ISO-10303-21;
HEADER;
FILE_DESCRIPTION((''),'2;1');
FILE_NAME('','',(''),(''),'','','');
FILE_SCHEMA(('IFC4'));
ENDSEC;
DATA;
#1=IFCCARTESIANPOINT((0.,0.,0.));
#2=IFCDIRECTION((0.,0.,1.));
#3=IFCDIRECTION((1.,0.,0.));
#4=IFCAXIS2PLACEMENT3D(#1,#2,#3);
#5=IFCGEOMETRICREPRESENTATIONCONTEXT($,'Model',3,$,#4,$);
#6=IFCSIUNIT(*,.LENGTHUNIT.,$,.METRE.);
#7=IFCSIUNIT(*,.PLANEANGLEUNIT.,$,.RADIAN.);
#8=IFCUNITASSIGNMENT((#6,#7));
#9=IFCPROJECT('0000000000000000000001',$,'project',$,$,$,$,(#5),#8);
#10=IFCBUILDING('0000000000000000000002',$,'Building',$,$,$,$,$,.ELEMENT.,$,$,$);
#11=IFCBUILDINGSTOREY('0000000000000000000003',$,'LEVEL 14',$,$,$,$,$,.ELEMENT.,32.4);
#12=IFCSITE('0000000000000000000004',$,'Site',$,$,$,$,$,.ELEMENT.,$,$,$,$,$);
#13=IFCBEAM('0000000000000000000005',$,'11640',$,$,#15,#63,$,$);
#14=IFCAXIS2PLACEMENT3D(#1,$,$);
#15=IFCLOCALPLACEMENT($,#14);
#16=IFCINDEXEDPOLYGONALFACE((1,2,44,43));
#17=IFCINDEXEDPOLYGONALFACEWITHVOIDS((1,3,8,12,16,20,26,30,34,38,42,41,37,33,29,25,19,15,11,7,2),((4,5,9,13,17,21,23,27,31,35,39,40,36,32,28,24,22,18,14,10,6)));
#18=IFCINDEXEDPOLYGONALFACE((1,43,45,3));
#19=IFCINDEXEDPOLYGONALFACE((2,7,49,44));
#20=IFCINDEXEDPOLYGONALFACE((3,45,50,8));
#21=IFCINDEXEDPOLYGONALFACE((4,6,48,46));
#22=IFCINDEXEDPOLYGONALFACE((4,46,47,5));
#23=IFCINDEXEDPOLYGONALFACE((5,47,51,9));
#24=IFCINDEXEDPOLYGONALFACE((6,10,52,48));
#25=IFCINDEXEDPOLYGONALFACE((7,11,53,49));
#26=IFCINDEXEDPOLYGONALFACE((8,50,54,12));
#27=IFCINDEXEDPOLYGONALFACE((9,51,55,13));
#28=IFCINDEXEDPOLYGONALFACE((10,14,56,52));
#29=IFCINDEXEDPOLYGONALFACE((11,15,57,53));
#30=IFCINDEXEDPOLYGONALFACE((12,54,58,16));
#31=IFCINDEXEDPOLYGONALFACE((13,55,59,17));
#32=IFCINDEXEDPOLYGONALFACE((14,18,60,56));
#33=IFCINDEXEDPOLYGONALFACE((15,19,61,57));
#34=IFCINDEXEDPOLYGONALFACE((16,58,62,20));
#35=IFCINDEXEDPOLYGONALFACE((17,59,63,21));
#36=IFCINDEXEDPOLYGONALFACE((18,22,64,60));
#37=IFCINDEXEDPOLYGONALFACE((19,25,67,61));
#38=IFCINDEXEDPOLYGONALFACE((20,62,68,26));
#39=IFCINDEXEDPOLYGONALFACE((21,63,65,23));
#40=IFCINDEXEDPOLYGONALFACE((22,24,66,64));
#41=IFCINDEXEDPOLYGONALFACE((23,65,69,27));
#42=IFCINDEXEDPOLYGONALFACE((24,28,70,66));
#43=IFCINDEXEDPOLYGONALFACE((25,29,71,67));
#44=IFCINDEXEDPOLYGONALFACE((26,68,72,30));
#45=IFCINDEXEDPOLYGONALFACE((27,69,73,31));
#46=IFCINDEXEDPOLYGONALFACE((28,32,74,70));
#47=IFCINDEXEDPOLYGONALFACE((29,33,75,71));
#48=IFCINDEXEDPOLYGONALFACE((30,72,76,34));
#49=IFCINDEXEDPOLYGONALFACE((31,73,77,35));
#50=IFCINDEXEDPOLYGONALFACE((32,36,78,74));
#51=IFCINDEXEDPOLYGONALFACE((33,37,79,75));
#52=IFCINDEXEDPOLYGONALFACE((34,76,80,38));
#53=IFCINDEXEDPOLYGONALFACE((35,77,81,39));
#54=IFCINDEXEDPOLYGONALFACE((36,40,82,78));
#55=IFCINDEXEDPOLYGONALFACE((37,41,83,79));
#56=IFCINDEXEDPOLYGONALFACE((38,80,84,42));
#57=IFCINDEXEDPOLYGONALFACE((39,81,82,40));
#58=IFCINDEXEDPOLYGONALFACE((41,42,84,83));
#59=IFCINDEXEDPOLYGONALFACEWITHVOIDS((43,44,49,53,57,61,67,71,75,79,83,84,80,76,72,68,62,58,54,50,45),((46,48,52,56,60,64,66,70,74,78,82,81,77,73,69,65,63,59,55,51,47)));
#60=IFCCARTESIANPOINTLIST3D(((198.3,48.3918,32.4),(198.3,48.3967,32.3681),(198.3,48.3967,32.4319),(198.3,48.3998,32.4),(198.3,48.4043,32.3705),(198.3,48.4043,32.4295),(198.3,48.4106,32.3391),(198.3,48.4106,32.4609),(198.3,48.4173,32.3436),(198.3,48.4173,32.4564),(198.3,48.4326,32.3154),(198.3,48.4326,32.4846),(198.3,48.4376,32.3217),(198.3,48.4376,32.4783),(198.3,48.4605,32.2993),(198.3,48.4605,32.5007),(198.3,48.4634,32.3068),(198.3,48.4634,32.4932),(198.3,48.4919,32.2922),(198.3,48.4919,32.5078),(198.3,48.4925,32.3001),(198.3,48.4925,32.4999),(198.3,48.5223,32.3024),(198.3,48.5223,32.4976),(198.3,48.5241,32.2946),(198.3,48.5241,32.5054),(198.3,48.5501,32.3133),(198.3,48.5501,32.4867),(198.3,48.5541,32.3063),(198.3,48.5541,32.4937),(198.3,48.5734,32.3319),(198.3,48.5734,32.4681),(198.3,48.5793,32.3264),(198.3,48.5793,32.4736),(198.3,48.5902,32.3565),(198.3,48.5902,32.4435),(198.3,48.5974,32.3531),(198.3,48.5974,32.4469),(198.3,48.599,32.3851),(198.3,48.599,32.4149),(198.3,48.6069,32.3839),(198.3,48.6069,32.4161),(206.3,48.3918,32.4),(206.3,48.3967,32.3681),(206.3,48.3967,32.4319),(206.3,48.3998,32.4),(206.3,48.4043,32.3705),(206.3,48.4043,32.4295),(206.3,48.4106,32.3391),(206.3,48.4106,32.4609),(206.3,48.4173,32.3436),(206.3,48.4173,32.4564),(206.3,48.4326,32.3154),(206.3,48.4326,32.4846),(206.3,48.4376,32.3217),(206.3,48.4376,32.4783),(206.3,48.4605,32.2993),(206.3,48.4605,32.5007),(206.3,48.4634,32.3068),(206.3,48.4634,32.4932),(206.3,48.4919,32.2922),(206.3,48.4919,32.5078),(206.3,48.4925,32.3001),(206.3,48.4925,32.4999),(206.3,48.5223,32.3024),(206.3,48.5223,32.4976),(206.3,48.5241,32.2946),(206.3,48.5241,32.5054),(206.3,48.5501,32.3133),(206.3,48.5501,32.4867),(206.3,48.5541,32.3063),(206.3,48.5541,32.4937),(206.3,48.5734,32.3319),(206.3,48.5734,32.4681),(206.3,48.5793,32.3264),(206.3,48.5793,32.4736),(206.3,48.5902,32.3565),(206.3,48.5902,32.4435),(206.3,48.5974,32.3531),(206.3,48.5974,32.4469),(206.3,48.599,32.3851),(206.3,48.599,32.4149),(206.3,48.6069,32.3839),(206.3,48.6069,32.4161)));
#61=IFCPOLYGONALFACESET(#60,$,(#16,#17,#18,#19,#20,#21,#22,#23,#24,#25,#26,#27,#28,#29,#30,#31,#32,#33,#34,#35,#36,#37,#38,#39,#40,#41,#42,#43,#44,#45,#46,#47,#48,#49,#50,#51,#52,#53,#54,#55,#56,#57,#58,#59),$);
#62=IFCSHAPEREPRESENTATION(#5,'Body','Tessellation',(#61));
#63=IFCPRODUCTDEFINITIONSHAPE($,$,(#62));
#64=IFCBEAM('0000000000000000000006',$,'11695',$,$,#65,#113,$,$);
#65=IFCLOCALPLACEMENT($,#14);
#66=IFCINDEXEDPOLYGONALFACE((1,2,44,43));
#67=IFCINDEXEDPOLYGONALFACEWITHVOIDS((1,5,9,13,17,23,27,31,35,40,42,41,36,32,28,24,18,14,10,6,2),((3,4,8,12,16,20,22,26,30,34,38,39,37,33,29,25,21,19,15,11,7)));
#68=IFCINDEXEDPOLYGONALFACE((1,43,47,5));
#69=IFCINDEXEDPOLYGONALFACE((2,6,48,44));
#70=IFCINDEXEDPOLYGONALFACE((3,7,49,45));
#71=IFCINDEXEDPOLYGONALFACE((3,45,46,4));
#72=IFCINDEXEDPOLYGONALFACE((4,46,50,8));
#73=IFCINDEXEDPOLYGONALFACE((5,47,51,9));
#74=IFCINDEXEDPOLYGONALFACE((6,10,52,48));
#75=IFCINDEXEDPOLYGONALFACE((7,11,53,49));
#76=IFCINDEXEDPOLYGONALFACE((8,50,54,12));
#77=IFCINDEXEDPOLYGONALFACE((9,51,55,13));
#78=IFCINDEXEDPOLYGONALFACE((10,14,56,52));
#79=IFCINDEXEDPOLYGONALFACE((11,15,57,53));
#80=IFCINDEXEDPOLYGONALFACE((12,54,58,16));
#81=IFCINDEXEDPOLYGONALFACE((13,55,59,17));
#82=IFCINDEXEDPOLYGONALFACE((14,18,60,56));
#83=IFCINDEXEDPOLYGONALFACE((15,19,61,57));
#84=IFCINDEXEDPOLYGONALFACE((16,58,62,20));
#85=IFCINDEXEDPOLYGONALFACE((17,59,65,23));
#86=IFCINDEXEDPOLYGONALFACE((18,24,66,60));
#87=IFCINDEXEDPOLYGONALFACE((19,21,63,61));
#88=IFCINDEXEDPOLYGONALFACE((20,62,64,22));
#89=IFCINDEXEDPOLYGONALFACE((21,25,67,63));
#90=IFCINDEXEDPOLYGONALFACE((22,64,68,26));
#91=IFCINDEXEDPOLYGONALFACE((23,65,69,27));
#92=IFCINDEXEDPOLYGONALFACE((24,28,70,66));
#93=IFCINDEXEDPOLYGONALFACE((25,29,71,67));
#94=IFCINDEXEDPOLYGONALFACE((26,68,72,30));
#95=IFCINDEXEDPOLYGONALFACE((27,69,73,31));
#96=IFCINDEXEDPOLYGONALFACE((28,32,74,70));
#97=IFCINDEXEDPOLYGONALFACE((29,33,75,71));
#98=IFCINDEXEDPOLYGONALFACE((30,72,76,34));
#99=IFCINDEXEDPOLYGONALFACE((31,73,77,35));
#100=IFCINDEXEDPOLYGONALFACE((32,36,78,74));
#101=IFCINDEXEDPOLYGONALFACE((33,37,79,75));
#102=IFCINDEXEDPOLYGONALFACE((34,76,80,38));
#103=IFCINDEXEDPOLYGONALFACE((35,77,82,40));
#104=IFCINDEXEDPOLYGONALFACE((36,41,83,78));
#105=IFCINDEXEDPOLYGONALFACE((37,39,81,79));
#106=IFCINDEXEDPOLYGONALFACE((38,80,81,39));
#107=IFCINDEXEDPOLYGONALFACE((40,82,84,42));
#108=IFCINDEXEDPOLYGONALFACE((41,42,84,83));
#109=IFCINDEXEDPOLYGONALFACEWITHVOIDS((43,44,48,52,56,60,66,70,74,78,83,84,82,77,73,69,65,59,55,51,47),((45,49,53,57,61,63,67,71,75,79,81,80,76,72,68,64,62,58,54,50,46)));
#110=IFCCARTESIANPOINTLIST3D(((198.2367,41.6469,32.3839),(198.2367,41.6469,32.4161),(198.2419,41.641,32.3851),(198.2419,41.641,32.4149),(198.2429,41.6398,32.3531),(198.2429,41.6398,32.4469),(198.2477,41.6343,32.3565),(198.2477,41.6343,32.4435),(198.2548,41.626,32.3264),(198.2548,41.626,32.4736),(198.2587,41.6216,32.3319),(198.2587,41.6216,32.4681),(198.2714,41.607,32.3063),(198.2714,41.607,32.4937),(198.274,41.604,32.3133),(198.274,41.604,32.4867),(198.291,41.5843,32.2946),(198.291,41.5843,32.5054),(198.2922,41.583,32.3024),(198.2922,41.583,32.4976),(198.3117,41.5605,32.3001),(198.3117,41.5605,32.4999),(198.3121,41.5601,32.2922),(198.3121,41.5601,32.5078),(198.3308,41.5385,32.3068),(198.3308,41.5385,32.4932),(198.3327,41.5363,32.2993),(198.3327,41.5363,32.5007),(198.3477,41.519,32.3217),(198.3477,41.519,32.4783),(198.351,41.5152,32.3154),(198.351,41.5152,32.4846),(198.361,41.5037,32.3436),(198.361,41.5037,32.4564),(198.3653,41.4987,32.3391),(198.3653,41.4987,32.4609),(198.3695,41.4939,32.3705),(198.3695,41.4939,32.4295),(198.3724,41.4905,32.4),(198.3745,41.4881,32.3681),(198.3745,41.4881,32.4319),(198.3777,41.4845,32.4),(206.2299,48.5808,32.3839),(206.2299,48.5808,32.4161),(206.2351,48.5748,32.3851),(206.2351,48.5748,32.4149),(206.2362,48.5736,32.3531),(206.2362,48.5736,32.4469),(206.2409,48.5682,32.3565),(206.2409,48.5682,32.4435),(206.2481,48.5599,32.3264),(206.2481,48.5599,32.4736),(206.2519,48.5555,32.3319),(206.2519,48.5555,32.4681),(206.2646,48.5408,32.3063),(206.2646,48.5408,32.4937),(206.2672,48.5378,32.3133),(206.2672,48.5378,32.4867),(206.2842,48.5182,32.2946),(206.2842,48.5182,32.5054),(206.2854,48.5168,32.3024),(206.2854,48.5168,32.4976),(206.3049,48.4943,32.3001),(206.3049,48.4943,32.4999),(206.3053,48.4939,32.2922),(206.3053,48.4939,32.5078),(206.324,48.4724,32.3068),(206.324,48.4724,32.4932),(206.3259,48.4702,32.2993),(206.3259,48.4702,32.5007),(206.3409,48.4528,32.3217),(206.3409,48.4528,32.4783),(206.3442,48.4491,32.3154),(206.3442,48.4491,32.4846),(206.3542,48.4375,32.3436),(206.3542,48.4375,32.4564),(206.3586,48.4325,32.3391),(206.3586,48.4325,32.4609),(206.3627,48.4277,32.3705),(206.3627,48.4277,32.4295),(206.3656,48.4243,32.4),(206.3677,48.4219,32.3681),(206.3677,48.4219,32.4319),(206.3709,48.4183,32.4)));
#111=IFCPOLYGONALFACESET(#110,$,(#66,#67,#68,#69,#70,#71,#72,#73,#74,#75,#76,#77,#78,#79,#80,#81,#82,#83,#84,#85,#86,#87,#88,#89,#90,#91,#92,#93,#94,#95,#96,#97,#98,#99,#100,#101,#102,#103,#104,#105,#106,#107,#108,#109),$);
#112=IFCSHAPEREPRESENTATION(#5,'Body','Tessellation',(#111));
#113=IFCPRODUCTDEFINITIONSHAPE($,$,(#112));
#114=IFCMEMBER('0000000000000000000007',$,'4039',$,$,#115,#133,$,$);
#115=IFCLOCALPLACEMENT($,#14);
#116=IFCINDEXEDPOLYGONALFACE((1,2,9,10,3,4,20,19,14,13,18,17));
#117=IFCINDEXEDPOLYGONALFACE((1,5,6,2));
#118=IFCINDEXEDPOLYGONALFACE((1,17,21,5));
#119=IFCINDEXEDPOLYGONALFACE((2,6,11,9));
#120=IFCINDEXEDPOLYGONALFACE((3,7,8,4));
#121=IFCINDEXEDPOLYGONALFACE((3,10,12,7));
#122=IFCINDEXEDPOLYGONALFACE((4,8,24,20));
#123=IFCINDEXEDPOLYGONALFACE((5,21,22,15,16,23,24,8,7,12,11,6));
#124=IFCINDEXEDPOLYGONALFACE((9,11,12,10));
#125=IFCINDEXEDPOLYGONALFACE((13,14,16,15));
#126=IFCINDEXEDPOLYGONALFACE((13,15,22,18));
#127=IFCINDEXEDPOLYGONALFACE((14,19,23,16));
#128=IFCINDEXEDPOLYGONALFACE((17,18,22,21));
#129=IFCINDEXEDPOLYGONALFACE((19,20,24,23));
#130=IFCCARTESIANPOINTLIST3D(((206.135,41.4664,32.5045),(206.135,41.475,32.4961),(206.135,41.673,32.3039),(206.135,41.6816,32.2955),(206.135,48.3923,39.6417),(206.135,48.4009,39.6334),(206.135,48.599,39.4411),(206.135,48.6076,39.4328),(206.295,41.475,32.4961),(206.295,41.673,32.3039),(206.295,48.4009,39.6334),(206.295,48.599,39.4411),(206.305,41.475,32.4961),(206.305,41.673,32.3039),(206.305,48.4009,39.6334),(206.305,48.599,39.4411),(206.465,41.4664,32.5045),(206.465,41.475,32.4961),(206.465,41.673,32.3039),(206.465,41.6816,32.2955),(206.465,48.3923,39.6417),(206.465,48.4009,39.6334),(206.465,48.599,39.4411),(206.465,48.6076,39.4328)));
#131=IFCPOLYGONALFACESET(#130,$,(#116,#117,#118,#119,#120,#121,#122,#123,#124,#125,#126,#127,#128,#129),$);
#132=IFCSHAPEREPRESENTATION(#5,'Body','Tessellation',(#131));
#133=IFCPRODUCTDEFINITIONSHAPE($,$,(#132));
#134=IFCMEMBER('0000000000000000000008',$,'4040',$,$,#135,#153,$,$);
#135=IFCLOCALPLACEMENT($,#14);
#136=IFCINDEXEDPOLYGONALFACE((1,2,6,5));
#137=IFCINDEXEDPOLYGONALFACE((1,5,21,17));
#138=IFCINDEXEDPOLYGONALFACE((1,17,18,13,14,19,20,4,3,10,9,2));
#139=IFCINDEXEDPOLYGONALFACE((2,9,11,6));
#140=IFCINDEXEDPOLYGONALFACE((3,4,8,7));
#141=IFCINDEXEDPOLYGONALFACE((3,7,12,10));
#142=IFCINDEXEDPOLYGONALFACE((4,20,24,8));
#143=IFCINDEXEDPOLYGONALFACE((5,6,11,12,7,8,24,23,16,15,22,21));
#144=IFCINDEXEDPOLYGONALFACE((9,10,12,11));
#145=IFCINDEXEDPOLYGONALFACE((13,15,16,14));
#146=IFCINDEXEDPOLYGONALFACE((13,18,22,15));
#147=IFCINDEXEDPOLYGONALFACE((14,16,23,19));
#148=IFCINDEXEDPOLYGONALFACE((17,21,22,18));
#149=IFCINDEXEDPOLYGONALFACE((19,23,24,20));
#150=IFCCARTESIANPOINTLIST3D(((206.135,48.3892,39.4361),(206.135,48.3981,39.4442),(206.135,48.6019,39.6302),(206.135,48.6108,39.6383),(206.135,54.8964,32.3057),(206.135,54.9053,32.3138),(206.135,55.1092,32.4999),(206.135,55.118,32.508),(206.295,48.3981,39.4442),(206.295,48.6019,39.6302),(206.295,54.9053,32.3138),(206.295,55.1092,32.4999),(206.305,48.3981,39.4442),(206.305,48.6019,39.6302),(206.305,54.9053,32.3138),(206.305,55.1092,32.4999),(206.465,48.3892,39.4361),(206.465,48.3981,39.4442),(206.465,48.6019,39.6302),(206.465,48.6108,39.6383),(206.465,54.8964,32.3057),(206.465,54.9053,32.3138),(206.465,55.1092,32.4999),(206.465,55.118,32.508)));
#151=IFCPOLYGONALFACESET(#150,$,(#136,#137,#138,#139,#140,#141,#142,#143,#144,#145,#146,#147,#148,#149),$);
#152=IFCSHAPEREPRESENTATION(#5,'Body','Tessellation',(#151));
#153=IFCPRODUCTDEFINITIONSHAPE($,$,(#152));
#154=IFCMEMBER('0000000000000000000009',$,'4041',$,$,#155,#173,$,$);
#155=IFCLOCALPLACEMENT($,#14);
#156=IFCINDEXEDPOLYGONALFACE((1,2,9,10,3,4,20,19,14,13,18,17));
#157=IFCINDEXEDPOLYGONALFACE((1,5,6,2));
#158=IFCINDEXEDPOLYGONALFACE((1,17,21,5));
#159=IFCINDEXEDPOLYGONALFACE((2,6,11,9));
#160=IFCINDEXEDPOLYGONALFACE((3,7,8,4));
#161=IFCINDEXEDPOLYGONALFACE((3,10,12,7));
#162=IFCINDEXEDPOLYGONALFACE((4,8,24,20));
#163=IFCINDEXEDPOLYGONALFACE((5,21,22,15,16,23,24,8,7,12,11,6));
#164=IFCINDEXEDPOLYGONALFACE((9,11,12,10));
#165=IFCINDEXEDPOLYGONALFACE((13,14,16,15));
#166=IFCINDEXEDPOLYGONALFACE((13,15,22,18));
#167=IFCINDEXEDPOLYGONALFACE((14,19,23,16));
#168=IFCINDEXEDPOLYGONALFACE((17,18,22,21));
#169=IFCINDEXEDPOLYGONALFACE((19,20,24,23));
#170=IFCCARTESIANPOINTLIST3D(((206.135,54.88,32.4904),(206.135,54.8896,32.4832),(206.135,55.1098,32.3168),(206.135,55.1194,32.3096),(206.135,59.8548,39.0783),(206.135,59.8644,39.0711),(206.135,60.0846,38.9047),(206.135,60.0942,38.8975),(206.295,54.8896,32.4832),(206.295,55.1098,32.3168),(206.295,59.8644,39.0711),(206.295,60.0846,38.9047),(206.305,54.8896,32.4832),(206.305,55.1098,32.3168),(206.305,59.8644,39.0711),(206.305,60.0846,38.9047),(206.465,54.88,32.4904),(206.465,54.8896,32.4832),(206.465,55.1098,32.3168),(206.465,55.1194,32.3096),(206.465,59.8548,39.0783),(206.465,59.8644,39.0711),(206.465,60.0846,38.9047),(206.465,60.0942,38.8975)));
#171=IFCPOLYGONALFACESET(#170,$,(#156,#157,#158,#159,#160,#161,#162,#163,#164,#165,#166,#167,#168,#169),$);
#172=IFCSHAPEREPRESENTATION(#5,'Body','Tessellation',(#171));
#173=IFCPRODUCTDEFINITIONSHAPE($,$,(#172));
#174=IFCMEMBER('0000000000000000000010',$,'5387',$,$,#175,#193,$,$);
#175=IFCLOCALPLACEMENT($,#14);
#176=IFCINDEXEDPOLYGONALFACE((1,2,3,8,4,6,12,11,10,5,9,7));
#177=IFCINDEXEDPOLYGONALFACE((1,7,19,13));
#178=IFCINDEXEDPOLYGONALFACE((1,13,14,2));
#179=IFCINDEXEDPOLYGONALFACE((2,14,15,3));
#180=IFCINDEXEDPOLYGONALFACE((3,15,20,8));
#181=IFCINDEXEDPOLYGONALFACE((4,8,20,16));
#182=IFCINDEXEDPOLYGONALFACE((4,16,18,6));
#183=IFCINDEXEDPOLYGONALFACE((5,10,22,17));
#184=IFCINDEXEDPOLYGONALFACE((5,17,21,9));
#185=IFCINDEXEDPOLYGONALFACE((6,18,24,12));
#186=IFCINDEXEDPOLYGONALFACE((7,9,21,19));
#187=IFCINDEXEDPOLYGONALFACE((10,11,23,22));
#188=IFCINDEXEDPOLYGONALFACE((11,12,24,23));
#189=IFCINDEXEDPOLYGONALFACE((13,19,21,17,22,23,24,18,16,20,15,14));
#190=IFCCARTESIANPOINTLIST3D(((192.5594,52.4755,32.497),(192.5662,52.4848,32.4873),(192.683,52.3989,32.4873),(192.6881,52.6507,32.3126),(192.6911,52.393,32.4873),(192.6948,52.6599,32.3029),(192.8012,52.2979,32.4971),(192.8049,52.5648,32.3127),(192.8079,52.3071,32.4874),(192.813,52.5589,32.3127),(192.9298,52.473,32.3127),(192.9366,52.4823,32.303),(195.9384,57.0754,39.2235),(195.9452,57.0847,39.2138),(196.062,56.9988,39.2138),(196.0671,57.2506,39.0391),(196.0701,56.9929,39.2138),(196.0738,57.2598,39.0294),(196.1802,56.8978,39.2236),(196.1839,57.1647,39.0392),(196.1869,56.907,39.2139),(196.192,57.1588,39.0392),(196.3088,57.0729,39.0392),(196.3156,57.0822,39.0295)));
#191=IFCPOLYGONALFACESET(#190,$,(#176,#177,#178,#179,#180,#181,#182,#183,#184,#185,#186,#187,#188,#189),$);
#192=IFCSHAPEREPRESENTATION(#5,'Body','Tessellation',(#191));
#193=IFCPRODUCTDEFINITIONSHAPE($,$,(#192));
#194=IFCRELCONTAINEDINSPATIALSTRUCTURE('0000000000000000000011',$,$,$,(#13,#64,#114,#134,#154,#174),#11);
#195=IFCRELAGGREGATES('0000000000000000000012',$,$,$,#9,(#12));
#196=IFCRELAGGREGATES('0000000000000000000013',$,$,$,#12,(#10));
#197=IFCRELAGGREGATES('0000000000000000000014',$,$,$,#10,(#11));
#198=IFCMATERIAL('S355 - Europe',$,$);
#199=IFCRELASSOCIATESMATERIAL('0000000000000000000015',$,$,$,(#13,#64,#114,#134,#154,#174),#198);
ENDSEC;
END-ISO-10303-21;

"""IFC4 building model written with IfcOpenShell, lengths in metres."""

from ifc_helpers import new_model, si_unit, frame, origin_with_axes, origin_2d_with_axis, place, context, project, spatial, hollow_circle, i_section, extrude, material, material_profile, profile_set, profile_usage, element, save


model = new_model("IFC4")

# Units and contexts
model_context = context("Model", 3, world=origin_with_axes())
ifc_project = project(units=[si_unit("LENGTHUNIT", "METRE"), si_unit("PLANEANGLEUNIT", "RADIAN")], contexts=[model_context])

# Site, building, storey
site = spatial("IfcSite", under=ifc_project, Name="Site", CompositionType="ELEMENT")
building = spatial("IfcBuilding", under=site, Name="Building", CompositionType="ELEMENT")
storey = spatial("IfcBuildingStorey", under=building, Name="LEVEL 14", CompositionType="ELEMENT", Elevation=32.4)

# Shared definitions
ifc_material = material(Name="S355 - Europe")

# Beams
ifc_material_profile_1 = material_profile(ifc_material, hollow_circle(Radius=0.1081, WallThickness=0.008, at=origin_2d_with_axis()))
ifc_profile_set_1 = profile_set([ifc_material_profile_1])
ifc_profile_usage_1 = profile_usage(ifc_profile_set_1, cardinal=10)
beam_1_placement = place(None, frame((206.3, 48.5, 32.4), z_axis=(-1.0, 0.0, 0.0), x_axis=(0.0, -1.0, 0.0)))
element("IfcBeam", 1, at=beam_1_placement, inside=storey, material=ifc_profile_usage_1, Name="11640", context=model_context, shape_type="SweptSolid", body=[
    extrude(hollow_circle(Radius=0.1081, WallThickness=0.008, at=origin_2d_with_axis()), origin_with_axes(), (0.0, 0.0, 1.0), 8.0),
])
ifc_material_profile_2 = material_profile(ifc_material, hollow_circle(Radius=0.1081, WallThickness=0.008, at=origin_2d_with_axis()))
ifc_profile_set_2 = profile_set([ifc_material_profile_2])
ifc_profile_usage_2 = profile_usage(ifc_profile_set_2, cardinal=10)
beam_2_placement = place(None, frame((206.3, 48.5, 32.4), z_axis=(-0.75539, -0.655276, 0.0), x_axis=(0.655276, -0.75539, 0.0)))
element("IfcBeam", 2, at=beam_2_placement, inside=storey, material=ifc_profile_usage_2, Name="11695", context=model_context, shape_type="SweptSolid", body=[
    extrude(hollow_circle(Radius=0.1081, WallThickness=0.008, at=origin_2d_with_axis()), origin_with_axes(), (0.0, 0.0, 1.0), 10.5816),
])

# Members
ifc_material_profile_3 = material_profile(ifc_material, i_section(OverallWidth=0.33, OverallDepth=0.3, WebThickness=0.01, FlangeThickness=0.012, at=origin_2d_with_axis()))
ifc_profile_set_3 = profile_set([ifc_material_profile_3])
ifc_profile_usage_3 = profile_usage(ifc_profile_set_3, cardinal=10)
member_1_placement = place(None, frame((206.3, 41.574, 32.4), z_axis=(0.0, 0.696404, 0.71765), x_axis=(-1.0, 0.0, 0.0)))
element("IfcMember", 3, at=member_1_placement, inside=storey, material=ifc_profile_usage_3, Name="4039", context=model_context, shape_type="SweptSolid", body=[
    extrude(i_section(OverallWidth=0.33, OverallDepth=0.3, WebThickness=0.01, FlangeThickness=0.012, at=origin_2d_with_axis()), origin_with_axes(), (0.0, 0.0, 1.0), 9.9453),
])
ifc_material_profile_4 = material_profile(ifc_material, i_section(OverallWidth=0.33, OverallDepth=0.3, WebThickness=0.01, FlangeThickness=0.012, at=origin_2d_with_axis()))
ifc_profile_set_4 = profile_set([ifc_material_profile_4])
ifc_profile_usage_4 = profile_usage(ifc_profile_set_4, cardinal=10)
member_2_placement = place(None, frame((206.3, 48.5, 39.5372), z_axis=(0.0, 0.674095, -0.738644), x_axis=(-1.0, 0.0, 0.0)))
element("IfcMember", 4, at=member_2_placement, inside=storey, material=ifc_profile_usage_4, Name="4040", context=model_context, shape_type="SweptSolid", body=[
    extrude(i_section(OverallWidth=0.33, OverallDepth=0.3, WebThickness=0.01, FlangeThickness=0.012, at=origin_2d_with_axis()), origin_with_axes(), (0.0, 0.0, 1.0), 9.6533),
])
ifc_material_profile_5 = material_profile(ifc_material, i_section(OverallWidth=0.33, OverallDepth=0.3, WebThickness=0.01, FlangeThickness=0.012, at=origin_2d_with_axis()))
ifc_profile_set_5 = profile_set([ifc_material_profile_5])
ifc_profile_usage_5 = profile_usage(ifc_profile_set_5, cardinal=10)
member_3_placement = place(None, frame((206.3, 54.9997, 32.4), z_axis=(0.0, 0.602623, 0.798026), x_axis=(-1.0, 0.0, 0.0)))
element("IfcMember", 5, at=member_3_placement, inside=storey, material=ifc_profile_usage_5, Name="4041", context=model_context, shape_type="SweptSolid", body=[
    extrude(i_section(OverallWidth=0.33, OverallDepth=0.3, WebThickness=0.01, FlangeThickness=0.012, at=origin_2d_with_axis()), origin_with_axes(), (0.0, 0.0, 1.0), 8.2552),
])
ifc_material_profile_6 = material_profile(ifc_material, i_section(OverallWidth=0.3, OverallDepth=0.3, WebThickness=0.01, FlangeThickness=0.015, at=origin_2d_with_axis()))
ifc_profile_set_6 = profile_set([ifc_material_profile_6])
ifc_profile_usage_6 = profile_usage(ifc_profile_set_6, cardinal=10)
member_4_placement = place(None, frame((192.748, 52.4789, 32.4), z_axis=(0.383032, 0.52143, 0.762494), x_axis=(-0.805846, 0.592125, 0.0)))
element("IfcMember", 6, at=member_4_placement, inside=storey, material=ifc_profile_usage_6, Name="5387", context=model_context, shape_type="SweptSolid", body=[
    extrude(i_section(OverallWidth=0.3, OverallDepth=0.3, WebThickness=0.01, FlangeThickness=0.015, at=origin_2d_with_axis()), origin_with_axes(), (0.0, 0.0, 1.0), 8.8217),
])

save(model, "model.ifc")
